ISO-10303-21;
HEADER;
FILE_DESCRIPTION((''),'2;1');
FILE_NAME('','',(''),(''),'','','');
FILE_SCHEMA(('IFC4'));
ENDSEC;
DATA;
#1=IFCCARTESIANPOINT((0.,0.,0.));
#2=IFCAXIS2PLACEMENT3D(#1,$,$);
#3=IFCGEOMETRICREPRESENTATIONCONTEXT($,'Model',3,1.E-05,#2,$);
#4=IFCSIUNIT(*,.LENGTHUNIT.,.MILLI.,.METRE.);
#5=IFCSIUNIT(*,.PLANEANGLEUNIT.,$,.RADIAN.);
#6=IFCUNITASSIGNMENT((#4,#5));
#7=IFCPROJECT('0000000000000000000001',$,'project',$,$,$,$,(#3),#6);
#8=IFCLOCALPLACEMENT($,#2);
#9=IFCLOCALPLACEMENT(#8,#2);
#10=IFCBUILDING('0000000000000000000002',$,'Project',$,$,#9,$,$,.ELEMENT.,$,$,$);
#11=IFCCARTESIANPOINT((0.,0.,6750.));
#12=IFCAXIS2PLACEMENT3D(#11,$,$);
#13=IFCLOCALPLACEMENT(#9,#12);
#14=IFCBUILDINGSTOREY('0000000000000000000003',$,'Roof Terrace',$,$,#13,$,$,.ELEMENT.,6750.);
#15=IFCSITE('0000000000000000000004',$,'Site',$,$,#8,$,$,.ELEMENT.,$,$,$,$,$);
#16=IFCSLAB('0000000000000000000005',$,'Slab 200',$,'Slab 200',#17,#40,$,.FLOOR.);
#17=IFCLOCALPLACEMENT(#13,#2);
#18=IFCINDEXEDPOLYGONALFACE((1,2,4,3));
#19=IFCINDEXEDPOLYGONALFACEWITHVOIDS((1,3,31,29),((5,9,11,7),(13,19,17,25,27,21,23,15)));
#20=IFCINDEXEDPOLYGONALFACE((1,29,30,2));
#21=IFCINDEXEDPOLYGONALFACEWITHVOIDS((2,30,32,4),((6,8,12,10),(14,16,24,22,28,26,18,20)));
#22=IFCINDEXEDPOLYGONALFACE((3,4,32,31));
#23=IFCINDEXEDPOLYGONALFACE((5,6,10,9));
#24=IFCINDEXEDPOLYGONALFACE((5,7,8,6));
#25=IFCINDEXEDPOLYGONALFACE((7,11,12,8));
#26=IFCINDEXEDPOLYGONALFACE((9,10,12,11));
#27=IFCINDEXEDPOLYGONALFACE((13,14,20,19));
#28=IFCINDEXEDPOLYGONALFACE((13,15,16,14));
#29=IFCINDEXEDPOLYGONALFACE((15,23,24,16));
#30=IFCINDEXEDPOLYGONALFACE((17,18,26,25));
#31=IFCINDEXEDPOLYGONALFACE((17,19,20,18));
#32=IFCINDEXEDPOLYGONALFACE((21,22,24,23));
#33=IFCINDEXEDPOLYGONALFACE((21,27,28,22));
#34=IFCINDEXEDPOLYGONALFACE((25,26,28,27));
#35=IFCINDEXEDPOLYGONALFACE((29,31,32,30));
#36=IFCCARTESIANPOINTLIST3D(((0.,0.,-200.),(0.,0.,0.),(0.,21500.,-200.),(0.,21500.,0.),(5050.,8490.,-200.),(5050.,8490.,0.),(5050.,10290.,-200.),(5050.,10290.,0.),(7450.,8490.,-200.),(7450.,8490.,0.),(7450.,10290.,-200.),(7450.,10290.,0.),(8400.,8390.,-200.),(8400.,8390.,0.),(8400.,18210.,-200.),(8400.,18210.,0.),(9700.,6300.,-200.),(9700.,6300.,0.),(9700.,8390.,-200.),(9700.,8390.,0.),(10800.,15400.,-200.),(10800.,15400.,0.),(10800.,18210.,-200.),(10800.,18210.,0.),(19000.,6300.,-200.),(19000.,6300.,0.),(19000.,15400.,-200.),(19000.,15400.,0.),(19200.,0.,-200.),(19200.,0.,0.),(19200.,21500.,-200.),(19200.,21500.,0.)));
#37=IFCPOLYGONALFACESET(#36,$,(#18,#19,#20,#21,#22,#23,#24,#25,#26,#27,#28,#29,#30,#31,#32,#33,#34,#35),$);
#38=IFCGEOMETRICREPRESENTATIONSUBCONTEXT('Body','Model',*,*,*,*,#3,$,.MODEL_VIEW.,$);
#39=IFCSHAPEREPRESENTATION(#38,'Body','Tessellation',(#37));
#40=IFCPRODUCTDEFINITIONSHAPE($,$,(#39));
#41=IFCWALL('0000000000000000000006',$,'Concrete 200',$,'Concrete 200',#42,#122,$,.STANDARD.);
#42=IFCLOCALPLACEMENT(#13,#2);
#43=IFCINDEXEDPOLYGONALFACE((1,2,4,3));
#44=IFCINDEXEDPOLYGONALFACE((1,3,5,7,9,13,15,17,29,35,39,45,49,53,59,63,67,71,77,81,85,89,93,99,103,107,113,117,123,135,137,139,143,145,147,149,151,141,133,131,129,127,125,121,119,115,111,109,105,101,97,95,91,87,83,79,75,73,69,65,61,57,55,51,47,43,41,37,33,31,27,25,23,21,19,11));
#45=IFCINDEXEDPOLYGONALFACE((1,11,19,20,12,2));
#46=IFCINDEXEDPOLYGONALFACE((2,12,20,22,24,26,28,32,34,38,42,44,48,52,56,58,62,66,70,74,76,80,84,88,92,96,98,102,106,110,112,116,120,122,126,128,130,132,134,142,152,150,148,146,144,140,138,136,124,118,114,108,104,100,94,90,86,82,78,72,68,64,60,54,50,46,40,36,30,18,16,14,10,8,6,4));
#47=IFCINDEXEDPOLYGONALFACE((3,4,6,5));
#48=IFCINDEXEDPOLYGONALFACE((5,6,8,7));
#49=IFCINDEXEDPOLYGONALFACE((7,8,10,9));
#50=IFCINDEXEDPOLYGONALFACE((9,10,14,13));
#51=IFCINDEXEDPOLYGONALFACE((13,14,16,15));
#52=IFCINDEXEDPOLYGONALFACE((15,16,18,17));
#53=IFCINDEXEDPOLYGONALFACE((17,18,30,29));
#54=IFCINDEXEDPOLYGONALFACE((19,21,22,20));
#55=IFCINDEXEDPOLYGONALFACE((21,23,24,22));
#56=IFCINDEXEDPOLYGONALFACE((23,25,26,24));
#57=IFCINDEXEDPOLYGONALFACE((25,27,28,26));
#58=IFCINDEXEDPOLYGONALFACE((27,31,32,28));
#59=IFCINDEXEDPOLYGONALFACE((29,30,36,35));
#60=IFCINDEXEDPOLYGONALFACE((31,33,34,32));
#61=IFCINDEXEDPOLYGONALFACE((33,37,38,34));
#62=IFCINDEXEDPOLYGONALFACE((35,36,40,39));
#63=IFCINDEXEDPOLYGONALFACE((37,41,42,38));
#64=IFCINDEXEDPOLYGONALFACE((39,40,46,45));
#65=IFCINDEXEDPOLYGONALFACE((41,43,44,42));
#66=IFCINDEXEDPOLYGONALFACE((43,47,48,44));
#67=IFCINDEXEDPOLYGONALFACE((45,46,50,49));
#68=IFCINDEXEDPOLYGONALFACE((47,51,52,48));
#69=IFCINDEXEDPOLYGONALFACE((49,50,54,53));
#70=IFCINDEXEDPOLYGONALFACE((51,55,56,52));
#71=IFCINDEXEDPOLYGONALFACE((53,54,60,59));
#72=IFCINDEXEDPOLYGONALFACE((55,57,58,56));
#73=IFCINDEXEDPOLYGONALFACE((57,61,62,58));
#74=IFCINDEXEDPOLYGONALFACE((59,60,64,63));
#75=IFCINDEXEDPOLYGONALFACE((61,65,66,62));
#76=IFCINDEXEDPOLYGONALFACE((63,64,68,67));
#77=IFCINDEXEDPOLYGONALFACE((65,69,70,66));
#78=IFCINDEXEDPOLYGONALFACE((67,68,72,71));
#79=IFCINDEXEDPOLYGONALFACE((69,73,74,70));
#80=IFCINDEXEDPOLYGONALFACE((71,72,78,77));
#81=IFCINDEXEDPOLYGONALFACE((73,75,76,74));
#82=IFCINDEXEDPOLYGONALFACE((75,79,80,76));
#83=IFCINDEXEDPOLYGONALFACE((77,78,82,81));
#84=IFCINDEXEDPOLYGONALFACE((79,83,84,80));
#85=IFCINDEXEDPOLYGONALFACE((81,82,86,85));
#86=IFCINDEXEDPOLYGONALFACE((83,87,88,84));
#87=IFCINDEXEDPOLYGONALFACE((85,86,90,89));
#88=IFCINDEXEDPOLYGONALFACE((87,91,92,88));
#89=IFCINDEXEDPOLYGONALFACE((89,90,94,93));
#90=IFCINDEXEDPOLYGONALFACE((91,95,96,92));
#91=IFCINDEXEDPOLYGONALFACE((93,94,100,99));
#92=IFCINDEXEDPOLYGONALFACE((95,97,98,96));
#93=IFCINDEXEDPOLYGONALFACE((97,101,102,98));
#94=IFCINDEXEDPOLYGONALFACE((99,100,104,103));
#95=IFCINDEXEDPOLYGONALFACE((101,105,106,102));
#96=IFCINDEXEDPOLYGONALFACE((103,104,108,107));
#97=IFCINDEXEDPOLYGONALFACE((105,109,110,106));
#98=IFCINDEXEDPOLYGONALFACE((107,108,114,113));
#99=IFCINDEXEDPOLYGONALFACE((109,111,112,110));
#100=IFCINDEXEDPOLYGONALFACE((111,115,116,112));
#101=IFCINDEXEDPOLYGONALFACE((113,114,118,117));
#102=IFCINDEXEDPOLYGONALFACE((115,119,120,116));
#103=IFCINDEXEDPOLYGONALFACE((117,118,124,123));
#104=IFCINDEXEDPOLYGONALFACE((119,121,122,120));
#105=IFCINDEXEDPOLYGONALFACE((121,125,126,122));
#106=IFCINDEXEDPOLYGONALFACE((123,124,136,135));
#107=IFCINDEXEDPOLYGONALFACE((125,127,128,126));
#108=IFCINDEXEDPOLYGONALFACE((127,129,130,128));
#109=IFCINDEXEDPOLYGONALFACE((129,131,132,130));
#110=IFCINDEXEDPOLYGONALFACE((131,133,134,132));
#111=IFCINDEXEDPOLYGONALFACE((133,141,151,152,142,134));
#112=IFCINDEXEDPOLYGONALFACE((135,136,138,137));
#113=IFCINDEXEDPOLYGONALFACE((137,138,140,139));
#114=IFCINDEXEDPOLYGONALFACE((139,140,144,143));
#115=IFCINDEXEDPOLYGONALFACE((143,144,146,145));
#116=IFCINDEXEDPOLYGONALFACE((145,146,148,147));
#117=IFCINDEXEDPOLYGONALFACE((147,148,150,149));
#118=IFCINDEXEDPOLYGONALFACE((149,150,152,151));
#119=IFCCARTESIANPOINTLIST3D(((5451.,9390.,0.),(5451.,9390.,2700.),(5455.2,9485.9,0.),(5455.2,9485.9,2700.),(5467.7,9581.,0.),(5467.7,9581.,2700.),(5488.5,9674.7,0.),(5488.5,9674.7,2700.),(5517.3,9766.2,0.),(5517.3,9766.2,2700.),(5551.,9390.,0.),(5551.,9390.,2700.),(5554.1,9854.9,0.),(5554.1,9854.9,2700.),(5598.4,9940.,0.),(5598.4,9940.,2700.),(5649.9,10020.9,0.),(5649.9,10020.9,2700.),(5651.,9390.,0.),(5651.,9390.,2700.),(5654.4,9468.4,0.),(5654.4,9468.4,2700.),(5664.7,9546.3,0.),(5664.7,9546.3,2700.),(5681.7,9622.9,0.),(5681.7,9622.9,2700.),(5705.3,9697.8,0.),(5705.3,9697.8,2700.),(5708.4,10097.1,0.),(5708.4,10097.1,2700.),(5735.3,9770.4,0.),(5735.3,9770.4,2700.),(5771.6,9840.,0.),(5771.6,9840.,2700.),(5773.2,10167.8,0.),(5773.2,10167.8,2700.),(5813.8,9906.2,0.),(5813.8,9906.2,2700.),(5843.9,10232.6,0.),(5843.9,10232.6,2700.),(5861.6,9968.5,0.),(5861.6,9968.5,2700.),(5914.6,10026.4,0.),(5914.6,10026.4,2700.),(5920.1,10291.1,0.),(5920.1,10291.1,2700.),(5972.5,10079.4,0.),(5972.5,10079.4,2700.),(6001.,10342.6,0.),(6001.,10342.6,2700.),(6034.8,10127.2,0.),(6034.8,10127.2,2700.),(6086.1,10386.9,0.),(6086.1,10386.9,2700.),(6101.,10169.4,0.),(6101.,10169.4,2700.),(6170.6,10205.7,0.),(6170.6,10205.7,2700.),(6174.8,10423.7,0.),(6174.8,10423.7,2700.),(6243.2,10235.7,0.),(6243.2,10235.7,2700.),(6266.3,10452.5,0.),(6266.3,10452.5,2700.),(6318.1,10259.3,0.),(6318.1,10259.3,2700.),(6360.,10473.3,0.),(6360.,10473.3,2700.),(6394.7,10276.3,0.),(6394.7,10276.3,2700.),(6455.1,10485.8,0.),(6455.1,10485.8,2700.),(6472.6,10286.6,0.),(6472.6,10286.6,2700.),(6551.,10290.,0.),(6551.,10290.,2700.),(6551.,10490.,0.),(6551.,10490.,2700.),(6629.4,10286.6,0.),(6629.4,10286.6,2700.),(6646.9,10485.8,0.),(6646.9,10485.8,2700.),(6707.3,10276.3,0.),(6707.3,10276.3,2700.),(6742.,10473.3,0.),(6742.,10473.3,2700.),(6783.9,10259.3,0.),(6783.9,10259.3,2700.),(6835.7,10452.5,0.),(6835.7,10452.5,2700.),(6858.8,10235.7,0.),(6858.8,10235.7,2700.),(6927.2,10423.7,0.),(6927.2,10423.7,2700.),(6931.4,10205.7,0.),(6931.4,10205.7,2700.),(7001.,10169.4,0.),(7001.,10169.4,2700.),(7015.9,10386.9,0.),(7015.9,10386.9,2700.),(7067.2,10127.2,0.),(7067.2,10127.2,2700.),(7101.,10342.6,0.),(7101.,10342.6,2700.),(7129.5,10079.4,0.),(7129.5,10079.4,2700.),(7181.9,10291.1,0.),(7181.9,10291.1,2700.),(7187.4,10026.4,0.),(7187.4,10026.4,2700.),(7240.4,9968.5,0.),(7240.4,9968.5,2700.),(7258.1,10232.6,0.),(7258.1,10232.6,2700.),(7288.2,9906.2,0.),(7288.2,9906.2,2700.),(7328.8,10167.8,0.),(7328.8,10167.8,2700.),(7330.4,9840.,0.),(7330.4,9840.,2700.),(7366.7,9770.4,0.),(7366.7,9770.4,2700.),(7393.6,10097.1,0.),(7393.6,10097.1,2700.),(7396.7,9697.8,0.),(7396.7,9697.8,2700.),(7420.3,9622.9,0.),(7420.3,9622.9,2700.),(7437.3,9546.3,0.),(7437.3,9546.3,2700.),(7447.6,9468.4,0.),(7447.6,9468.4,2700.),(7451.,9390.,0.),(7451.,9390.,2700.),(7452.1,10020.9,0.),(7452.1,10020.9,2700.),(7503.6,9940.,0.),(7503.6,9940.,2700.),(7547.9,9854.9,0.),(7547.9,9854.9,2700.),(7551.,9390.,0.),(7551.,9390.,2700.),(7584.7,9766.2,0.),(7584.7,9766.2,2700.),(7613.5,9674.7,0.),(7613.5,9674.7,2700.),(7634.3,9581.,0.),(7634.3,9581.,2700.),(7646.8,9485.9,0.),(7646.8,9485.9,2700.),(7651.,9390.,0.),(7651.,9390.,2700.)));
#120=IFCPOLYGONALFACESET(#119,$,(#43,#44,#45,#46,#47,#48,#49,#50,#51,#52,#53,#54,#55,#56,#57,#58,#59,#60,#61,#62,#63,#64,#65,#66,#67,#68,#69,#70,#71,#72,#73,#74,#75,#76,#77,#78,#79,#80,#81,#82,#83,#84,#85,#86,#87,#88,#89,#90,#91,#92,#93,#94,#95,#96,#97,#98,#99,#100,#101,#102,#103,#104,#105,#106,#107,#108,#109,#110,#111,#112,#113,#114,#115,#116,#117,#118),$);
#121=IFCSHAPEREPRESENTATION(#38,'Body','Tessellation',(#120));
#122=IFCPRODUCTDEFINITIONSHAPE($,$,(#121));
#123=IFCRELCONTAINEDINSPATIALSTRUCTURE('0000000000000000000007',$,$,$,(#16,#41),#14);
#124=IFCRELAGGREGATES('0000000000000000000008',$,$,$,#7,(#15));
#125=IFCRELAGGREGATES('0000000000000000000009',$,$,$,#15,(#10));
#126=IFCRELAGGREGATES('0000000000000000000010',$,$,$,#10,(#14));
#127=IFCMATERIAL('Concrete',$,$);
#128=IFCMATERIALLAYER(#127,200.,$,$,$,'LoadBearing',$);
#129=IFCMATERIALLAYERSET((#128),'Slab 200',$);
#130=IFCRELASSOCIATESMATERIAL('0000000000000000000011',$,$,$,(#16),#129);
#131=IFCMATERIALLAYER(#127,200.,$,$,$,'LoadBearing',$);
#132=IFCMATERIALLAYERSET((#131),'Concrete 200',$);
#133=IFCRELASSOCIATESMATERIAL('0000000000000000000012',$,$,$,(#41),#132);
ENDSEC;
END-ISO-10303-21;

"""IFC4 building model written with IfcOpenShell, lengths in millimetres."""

from ifc_helpers import new_model, si_unit, frame, origin, place, context, subcontext, project, spatial, polyline, outline, extrude, material, layer, layer_set, layer_usage, element, save


model = new_model("IFC4")

# Units and contexts
model_context = context("Model", 3, precision=1e-05, world=origin())
body_context = subcontext(model_context, "Body", "Model", "MODEL_VIEW")
ifc_project = project(units=[si_unit("LENGTHUNIT", "METRE", prefix="MILLI"), si_unit("PLANEANGLEUNIT", "RADIAN")], contexts=[model_context])

# Site, building, storey
site_placement = place(None, origin())
site = spatial("IfcSite", under=ifc_project, at=site_placement, Name="Site", CompositionType="ELEMENT")
building_placement = place(site_placement, origin())
building = spatial("IfcBuilding", under=site, at=building_placement, Name="Project", CompositionType="ELEMENT")
storey_placement = place(building_placement, frame((0.0, 0.0, 6750.0)))
storey = spatial("IfcBuildingStorey", under=building, at=storey_placement, Name="Roof Terrace", CompositionType="ELEMENT", Elevation=6750.0)

# Slab
ifc_material = material(Name="Concrete")
ifc_layer_1 = layer(ifc_material, 200.0, Category="LoadBearing")
ifc_layer_set_1 = layer_set([ifc_layer_1], Name="Slab 200")
ifc_layer_usage_1 = layer_usage(ifc_layer_set_1, "AXIS3", "NEGATIVE", 0.0)
slab_placement = place(storey_placement, origin())
element("IfcSlab", 1, at=slab_placement, inside=storey, material=ifc_layer_usage_1, Name="Slab 200", ObjectType="Slab 200", PredefinedType="FLOOR", context=body_context, shape_type="SweptSolid", body=[
    extrude(outline(polyline([(0.0, 0.0), (19200.0, 0.0), (19200.0, 21500.0), (0.0, 21500.0), (0.0, 0.0)]), holes=[polyline([(9700.0, 6300.0), (19000.0, 6300.0), (19000.0, 15400.0), (10800.0, 15400.0), (10800.0, 18210.0), (8400.0, 18210.0), (8400.0, 8390.0), (9700.0, 8390.0), (9700.0, 6300.0)]), polyline([(5050.0, 8490.0), (7450.0, 8490.0), (7450.0, 10290.0), (5050.0, 10290.0), (5050.0, 8490.0)])]), frame((0.0, 0.0, -200.0)), (0.0, 0.0, 1.0), 200.0),
])

# Wall
ifc_layer_2 = layer(ifc_material, 200.0, Category="LoadBearing")
ifc_layer_set_2 = layer_set([ifc_layer_2], Name="Concrete 200")
ifc_layer_usage_2 = layer_usage(ifc_layer_set_2, "AXIS2", "NEGATIVE", 100.0)
wall_1_placement = place(storey_placement, frame((7551.0, 9390.0, 0.0), z_axis=(0.0, 0.0, 1.0), x_axis=(0.0, 1.0, 0.0)))
element("IfcWall", 2, at=wall_1_placement, inside=storey, material=ifc_layer_usage_2, Name="Concrete 200", ObjectType="Concrete 200", PredefinedType="STANDARD", context=body_context, shape_type="SweptSolid", body=[
    extrude(outline(polyline([(0.0, -100.0), (0.0, 0.0), (0.0, 100.0), (78.4, 103.4), (156.3, 113.7), (232.9, 130.7), (307.8, 154.3), (380.4, 184.3), (450.0, 220.6), (516.2, 262.8), (578.5, 310.6), (636.4, 363.6), (689.4, 421.5), (737.2, 483.8), (779.4, 550.0), (815.7, 619.6), (845.7, 692.2), (869.3, 767.1), (886.3, 843.7), (896.6, 921.6), (900.0, 1000.0), (896.6, 1078.4), (886.3, 1156.3), (869.3, 1232.9), (845.7, 1307.8), (815.7, 1380.4), (779.4, 1450.0), (737.2, 1516.2), (689.4, 1578.5), (636.4, 1636.4), (578.5, 1689.4), (516.2, 1737.2), (450.0, 1779.4), (380.4, 1815.7), (307.8, 1845.7), (232.9, 1869.3), (156.3, 1886.3), (78.4, 1896.6), (0.0, 1900.0), (0.0, 2000.0), (0.0, 2100.0), (95.9, 2095.8), (191.0, 2083.3), (284.7, 2062.5), (376.2, 2033.7), (464.9, 1996.9), (550.0, 1952.6), (630.9, 1901.1), (707.1, 1842.6), (777.8, 1777.8), (842.6, 1707.1), (901.1, 1630.9), (952.6, 1550.0), (996.9, 1464.9), (1033.7, 1376.2), (1062.5, 1284.7), (1083.3, 1191.0), (1095.8, 1095.9), (1100.0, 1000.0), (1095.8, 904.1), (1083.3, 809.0), (1062.5, 715.3), (1033.7, 623.8), (996.9, 535.1), (952.6, 450.0), (901.1, 369.1), (842.6, 292.9), (777.8, 222.2), (707.1, 157.4), (630.9, 98.9), (550.0, 47.4), (464.9, 3.1), (376.2, -33.7), (284.7, -62.5), (191.0, -83.3), (95.9, -95.8), (0.0, -100.0)])), origin(), (0.0, 0.0, 1.0), 2700.0),
])

save(model, "model.ifc")
